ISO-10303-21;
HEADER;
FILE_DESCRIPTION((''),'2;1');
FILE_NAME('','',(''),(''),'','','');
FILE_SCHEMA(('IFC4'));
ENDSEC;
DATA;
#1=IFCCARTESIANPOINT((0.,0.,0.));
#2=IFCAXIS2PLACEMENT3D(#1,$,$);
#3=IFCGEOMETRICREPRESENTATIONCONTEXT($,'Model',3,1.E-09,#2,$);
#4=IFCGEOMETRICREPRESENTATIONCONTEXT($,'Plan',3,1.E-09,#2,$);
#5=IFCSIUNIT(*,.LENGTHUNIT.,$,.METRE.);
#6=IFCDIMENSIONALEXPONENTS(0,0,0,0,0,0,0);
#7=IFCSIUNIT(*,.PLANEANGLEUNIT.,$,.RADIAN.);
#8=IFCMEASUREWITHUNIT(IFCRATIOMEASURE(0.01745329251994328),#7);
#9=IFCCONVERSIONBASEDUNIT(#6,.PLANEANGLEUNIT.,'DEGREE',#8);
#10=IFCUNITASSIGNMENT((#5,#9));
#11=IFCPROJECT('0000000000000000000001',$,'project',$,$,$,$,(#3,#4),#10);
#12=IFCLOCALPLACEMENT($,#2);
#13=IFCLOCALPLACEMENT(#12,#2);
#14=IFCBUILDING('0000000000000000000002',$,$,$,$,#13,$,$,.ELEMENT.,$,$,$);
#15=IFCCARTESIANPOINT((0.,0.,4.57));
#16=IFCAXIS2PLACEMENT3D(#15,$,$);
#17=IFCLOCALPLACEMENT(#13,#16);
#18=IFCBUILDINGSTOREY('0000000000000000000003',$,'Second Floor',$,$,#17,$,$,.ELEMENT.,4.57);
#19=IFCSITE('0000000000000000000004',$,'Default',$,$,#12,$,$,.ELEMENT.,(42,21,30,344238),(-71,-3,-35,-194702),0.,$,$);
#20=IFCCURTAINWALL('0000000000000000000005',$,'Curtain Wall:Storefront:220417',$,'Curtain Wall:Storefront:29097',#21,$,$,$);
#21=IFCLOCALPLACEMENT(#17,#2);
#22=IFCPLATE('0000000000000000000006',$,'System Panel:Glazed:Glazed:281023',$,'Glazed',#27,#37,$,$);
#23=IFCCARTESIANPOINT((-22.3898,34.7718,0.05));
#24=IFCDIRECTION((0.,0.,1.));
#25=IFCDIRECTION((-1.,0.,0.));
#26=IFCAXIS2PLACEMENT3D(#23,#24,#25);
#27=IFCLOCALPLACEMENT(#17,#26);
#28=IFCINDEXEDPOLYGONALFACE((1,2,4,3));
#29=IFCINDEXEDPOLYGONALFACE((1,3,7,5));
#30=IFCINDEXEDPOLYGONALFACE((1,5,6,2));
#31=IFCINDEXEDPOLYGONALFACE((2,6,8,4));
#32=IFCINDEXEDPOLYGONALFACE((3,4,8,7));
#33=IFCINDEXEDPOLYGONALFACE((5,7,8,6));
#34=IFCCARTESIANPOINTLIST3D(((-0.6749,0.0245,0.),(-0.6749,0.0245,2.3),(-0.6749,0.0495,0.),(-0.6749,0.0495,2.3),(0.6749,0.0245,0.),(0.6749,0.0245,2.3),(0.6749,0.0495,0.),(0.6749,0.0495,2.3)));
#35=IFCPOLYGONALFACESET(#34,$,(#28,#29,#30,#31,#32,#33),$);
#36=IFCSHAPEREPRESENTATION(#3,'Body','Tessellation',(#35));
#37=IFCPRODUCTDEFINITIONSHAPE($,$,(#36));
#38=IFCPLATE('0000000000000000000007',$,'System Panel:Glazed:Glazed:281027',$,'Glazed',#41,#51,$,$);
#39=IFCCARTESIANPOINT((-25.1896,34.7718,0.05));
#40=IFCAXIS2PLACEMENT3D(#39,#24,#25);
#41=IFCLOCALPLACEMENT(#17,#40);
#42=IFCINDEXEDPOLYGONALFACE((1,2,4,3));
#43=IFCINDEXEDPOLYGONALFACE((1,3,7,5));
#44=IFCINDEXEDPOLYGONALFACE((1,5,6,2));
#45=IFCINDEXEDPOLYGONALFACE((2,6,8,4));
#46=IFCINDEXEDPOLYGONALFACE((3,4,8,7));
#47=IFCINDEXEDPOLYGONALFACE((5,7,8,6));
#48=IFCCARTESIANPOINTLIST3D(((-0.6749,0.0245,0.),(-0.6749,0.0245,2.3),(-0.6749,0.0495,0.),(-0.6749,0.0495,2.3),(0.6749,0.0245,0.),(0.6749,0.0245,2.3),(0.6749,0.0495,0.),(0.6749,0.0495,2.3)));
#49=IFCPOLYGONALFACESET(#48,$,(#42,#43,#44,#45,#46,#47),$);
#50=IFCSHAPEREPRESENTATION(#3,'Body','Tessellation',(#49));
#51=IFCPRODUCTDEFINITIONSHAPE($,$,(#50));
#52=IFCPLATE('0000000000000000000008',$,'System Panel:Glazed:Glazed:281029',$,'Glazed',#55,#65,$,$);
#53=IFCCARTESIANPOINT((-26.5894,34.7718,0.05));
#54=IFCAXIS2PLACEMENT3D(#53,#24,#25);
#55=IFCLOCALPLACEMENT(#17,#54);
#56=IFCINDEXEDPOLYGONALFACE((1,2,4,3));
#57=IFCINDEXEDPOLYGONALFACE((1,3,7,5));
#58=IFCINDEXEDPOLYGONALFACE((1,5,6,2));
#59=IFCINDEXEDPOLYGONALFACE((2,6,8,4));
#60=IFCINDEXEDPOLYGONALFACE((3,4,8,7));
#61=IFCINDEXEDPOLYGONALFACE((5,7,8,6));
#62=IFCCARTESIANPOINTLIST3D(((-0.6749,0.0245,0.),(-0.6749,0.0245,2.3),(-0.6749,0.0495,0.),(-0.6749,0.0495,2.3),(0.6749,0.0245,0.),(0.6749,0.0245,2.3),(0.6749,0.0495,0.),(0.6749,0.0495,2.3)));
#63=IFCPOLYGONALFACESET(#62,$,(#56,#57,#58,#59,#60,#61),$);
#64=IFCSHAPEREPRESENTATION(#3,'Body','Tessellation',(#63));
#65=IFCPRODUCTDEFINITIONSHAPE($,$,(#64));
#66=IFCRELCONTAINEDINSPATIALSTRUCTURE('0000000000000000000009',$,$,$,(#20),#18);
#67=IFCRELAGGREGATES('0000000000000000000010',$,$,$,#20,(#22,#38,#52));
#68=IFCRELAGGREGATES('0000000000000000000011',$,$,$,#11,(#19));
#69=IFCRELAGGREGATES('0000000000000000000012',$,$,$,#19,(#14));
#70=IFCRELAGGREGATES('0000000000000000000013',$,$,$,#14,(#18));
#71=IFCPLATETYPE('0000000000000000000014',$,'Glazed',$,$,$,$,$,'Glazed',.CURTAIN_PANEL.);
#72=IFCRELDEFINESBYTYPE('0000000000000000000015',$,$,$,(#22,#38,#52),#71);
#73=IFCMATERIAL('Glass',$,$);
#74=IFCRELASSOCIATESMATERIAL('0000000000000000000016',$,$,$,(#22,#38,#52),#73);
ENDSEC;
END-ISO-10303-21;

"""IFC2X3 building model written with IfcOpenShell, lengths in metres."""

from ifc_helpers import new_model, entity, si_unit, converted_unit, frame, origin, origin_2d_with_axis, place, context, project, spatial, rectangle, extrude, source, transform, mapped, material, type_object, type_shapes, element, aggregate, save


model = new_model("IFC2X3")

# Units and contexts
model_context = context("Model", 3, precision=1e-09, world=origin())
plan_context = context("Plan", 3, precision=1e-09, world=origin())
ifc_project = project(units=[si_unit("LENGTHUNIT", "METRE"), converted_unit("PLANEANGLEUNIT", "DEGREE", entity("IfcRatioMeasure", 0.01745329251994328), si_unit("PLANEANGLEUNIT", "RADIAN"), dimensions=[0, 0, 0, 0, 0, 0, 0])], contexts=[model_context, plan_context])

# Site, building, storey
site_placement = place(None, origin())
site = spatial("IfcSite", under=ifc_project, at=site_placement, Name="Default", CompositionType="ELEMENT", RefLatitude=(42, 21, 30, 344238), RefLongitude=(-71, -3, -35, -194702), RefElevation=0.0)
building_placement = place(site_placement, origin())
building = spatial("IfcBuilding", under=site, at=building_placement, CompositionType="ELEMENT")
storey_placement = place(building_placement, frame((0.0, 0.0, 4.57)))
storey = spatial("IfcBuildingStorey", under=building, at=storey_placement, Name="Second Floor", CompositionType="ELEMENT", Elevation=4.57)

# Curtain wall, plates
curtain_wall_placement = place(storey_placement, origin())
curtain_wall = element("IfcCurtainWall", 1, at=curtain_wall_placement, inside=storey, Name="Curtain Wall:Storefront:220417", ObjectType="Curtain Wall:Storefront:29097")
ifc_material_1 = material(Name="Glass")
plate_type = type_object("IfcPlateType", Name="Glazed", ElementType="Glazed", PredefinedType="CURTAIN_PANEL")
shared_shape_1 = source(origin(), model_context, "Body", "SweptSolid", [
    extrude(rectangle(XDim=0.025, YDim=1.3499, at=origin_2d_with_axis()), frame((0.0, 0.037, 0.0), z_axis=(0.0, 0.0, 1.0), x_axis=(0.0, 1.0, 0.0)), (0.0, 0.0, 1.0), 2.3),
])
type_shapes(plate_type, [shared_shape_1])
plate_1_placement = place(storey_placement, frame((-22.3898, 34.7718, 0.05), z_axis=(0.0, 0.0, 1.0), x_axis=(-1.0, 0.0, 0.0)))
plate_1 = element("IfcPlate", 2, at=plate_1_placement, type_object=plate_type, material=ifc_material_1, Name="System Panel:Glazed:Glazed:281023", ObjectType="Glazed", context=model_context, shape_type="MappedRepresentation", body=[
    mapped(shared_shape_1, transform((0.0, 0.0, 0.0), scale=1.0)),
])
plate_2_placement = place(storey_placement, frame((-25.1896, 34.7718, 0.05), z_axis=(0.0, 0.0, 1.0), x_axis=(-1.0, 0.0, 0.0)))
plate_2 = element("IfcPlate", 3, at=plate_2_placement, type_object=plate_type, material=ifc_material_1, Name="System Panel:Glazed:Glazed:281027", ObjectType="Glazed", context=model_context, shape_type="MappedRepresentation", body=[
    mapped(shared_shape_1, transform((0.0, 0.0, 0.0), scale=1.0)),
])
plate_3_placement = place(storey_placement, frame((-26.5894, 34.7718, 0.05), z_axis=(0.0, 0.0, 1.0), x_axis=(-1.0, 0.0, 0.0)))
plate_3 = element("IfcPlate", 4, at=plate_3_placement, type_object=plate_type, material=ifc_material_1, Name="System Panel:Glazed:Glazed:281029", ObjectType="Glazed", context=model_context, shape_type="MappedRepresentation", body=[
    mapped(shared_shape_1, transform((0.0, 0.0, 0.0), scale=1.0)),
])
aggregate(curtain_wall, [plate_1, plate_2, plate_3])

save(model, "model.ifc")
